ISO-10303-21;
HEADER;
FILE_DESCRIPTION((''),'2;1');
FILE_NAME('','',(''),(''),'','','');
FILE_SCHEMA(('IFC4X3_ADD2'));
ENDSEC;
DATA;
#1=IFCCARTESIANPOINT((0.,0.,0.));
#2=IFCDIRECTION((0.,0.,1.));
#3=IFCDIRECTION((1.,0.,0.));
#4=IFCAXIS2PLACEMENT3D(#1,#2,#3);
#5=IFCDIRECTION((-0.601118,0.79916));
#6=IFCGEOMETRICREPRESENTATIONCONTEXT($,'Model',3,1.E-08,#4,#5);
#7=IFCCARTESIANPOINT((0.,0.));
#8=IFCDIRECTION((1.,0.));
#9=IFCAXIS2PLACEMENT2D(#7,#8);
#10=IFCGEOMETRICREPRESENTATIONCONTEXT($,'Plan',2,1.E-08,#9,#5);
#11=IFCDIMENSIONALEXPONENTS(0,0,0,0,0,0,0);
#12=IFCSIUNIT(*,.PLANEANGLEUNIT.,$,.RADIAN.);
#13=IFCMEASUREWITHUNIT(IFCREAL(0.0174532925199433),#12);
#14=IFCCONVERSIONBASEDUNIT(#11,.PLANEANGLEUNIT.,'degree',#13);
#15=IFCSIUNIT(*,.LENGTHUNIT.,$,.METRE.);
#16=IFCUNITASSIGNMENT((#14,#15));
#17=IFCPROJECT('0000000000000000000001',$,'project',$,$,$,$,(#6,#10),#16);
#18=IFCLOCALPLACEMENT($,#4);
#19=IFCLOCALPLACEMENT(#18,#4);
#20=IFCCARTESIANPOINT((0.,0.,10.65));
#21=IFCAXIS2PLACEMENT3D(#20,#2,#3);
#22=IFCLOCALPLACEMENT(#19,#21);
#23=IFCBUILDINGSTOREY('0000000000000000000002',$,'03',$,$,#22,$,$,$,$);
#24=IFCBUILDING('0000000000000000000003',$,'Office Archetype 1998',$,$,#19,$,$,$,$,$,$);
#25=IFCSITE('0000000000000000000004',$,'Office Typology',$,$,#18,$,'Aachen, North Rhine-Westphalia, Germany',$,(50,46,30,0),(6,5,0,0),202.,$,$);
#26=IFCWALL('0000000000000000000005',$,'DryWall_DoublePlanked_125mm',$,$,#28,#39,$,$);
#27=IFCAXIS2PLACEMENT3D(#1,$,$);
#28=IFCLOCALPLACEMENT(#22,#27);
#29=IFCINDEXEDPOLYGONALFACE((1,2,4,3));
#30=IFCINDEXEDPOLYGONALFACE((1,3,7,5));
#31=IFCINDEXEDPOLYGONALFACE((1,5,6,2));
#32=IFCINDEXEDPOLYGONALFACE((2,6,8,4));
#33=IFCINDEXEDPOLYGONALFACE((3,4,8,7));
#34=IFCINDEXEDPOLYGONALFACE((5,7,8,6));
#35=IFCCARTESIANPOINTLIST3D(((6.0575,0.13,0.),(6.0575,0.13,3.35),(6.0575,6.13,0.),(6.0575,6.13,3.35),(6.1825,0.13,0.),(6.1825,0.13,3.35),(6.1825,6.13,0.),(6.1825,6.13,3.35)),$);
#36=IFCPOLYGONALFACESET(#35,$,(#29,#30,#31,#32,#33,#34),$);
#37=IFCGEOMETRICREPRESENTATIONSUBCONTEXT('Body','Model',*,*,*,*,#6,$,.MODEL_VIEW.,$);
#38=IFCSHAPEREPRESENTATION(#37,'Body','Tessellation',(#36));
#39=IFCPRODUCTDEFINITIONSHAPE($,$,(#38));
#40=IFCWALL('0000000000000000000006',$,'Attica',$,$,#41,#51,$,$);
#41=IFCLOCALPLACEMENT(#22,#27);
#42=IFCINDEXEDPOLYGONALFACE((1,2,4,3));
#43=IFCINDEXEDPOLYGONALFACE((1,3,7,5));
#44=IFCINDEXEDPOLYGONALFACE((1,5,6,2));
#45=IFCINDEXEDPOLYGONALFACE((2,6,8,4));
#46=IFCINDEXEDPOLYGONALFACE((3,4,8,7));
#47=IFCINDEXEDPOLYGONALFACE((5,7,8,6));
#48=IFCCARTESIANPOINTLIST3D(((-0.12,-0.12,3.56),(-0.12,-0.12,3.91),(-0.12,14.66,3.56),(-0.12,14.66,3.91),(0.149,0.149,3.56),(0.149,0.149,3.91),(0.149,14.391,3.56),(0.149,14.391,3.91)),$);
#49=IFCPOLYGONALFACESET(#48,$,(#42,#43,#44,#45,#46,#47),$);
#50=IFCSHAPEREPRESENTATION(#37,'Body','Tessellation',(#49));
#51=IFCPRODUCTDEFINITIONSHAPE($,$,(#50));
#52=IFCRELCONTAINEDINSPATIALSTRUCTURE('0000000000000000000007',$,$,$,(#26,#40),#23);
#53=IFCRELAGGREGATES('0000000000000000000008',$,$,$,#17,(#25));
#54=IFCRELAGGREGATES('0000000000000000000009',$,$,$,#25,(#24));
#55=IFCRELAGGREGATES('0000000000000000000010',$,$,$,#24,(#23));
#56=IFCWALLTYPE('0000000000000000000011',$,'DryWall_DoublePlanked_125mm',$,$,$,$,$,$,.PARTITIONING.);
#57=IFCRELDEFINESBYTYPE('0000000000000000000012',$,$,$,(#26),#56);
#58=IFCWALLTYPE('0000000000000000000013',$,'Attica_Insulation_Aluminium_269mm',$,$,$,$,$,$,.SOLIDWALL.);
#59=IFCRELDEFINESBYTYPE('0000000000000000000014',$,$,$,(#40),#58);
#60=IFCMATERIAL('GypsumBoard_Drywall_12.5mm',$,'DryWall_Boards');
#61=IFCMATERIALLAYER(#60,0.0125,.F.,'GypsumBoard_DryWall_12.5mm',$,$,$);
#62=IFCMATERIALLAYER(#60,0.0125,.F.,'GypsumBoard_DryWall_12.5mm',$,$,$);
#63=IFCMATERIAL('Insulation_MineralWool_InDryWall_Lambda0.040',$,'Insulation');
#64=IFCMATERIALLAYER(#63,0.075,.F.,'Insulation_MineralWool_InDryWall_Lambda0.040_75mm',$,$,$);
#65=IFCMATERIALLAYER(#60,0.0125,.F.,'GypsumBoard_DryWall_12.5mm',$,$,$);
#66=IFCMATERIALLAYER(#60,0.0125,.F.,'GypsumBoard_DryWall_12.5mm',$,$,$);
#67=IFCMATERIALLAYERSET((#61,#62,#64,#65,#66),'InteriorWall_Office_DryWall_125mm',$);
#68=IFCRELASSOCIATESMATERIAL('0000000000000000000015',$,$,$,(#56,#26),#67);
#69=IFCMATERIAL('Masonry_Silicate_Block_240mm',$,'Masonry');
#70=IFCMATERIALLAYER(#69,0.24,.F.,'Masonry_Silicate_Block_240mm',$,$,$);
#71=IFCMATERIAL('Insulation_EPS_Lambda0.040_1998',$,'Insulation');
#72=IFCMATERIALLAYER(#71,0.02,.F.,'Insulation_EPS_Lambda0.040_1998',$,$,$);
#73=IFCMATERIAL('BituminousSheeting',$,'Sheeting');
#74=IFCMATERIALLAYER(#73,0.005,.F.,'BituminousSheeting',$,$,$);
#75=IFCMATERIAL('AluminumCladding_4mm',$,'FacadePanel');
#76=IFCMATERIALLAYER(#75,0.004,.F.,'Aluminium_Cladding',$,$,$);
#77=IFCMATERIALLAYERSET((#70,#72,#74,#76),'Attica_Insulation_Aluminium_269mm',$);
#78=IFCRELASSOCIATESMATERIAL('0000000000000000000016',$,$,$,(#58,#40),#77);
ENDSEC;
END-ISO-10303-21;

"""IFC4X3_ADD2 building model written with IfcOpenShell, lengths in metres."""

from ifc_helpers import new_model, entity, si_unit, converted_unit, direction, frame, origin_with_axes, origin_2d_with_axis, place, context, subcontext, project, spatial, line, indexed_curve, outline, extrude, material, layer, layer_set, layer_usage, type_object, element, save


model = new_model("IFC4X3_ADD2")

# Units and contexts
model_context = context("Model", 3, precision=1e-08, world=origin_with_axes(), true_north=direction((-0.601118, 0.79916)))
plan_context = context("Plan", 2, precision=1e-08, world=origin_2d_with_axis(), true_north=direction((-0.601118, 0.79916)))
body_context = subcontext(model_context, "Body", "Model", "MODEL_VIEW")
ifc_project = project(units=[converted_unit("PLANEANGLEUNIT", "degree", entity("IfcReal", 0.0174532925199433), si_unit("PLANEANGLEUNIT", "RADIAN"), dimensions=[0, 0, 0, 0, 0, 0, 0]), si_unit("LENGTHUNIT", "METRE")], contexts=[model_context, plan_context])

# Site, building, storey
site_placement = place(None, origin_with_axes())
site = spatial("IfcSite", under=ifc_project, at=site_placement, Name="Office Typology", LongName="Aachen, North Rhine-Westphalia, Germany", RefLatitude=(50, 46, 30, 0), RefLongitude=(6, 5, 0, 0), RefElevation=202.0)
building_placement = place(site_placement, origin_with_axes())
building = spatial("IfcBuilding", under=site, at=building_placement, Name="Office Archetype 1998")
storey_placement = place(building_placement, frame((0.0, 0.0, 10.65), z_axis=(0.0, 0.0, 1.0), x_axis=(1.0, 0.0, 0.0)))
storey = spatial("IfcBuildingStorey", under=building, at=storey_placement, Name="03")

# Shared definitions
ifc_material_1 = material(Name="Masonry_Silicate_Block_240mm", Category="Masonry")

# Wall
ifc_material_2 = material(Name="GypsumBoard_Drywall_12.5mm", Category="DryWall_Boards")
ifc_layer_1 = layer(ifc_material_2, 0.0125, ventilated=False, Name="GypsumBoard_DryWall_12.5mm")
ifc_layer_2 = layer(ifc_material_2, 0.0125, ventilated=False, Name="GypsumBoard_DryWall_12.5mm")
ifc_material_3 = material(Name="Insulation_MineralWool_InDryWall_Lambda0.040", Category="Insulation")
ifc_layer_3 = layer(ifc_material_3, 0.075, ventilated=False, Name="Insulation_MineralWool_InDryWall_Lambda0.040_75mm")
ifc_layer_4 = layer(ifc_material_2, 0.0125, ventilated=False, Name="GypsumBoard_DryWall_12.5mm")
ifc_layer_5 = layer(ifc_material_2, 0.0125, ventilated=False, Name="GypsumBoard_DryWall_12.5mm")
ifc_layer_set_1 = layer_set([ifc_layer_1, ifc_layer_2, ifc_layer_3, ifc_layer_4, ifc_layer_5], Name="InteriorWall_Office_DryWall_125mm")
ifc_layer_usage_1 = layer_usage(ifc_layer_set_1, "AXIS2", "POSITIVE", 0.0)
wall_type_1 = type_object("IfcWallType", Name="DryWall_DoublePlanked_125mm", PredefinedType="PARTITIONING", material=ifc_layer_set_1)
wall_1_placement = place(storey_placement, frame((6.0575, 6.13, 0.0), z_axis=(0.0, 0.0, 1.0), x_axis=(0.0, -1.0, 0.0)))
element("IfcWall", 1, at=wall_1_placement, inside=storey, type_object=wall_type_1, material=ifc_layer_usage_1, Name="DryWall_DoublePlanked_125mm", context=body_context, shape_type="SweptSolid", body=[
    extrude(outline(indexed_curve([(0.0, 0.0), (0.0, 0.125), (6.0, 0.125), (6.0, 0.0)], segments=[line(1, 2, 3, 4, 1)])), origin_with_axes(), (0.0, 0.0, 1.0), 3.35),
])

# Wall
ifc_layer_6 = layer(ifc_material_1, 0.24, ventilated=False, Name="Masonry_Silicate_Block_240mm")
ifc_material_4 = material(Name="Insulation_EPS_Lambda0.040_1998", Category="Insulation")
ifc_layer_7 = layer(ifc_material_4, 0.02, ventilated=False, Name="Insulation_EPS_Lambda0.040_1998")
ifc_material_5 = material(Name="BituminousSheeting", Category="Sheeting")
ifc_layer_8 = layer(ifc_material_5, 0.005, ventilated=False, Name="BituminousSheeting")
ifc_material_6 = material(Name="AluminumCladding_4mm", Category="FacadePanel")
ifc_layer_9 = layer(ifc_material_6, 0.004, ventilated=False, Name="Aluminium_Cladding")
ifc_layer_set_2 = layer_set([ifc_layer_6, ifc_layer_7, ifc_layer_8, ifc_layer_9], Name="Attica_Insulation_Aluminium_269mm")
ifc_layer_usage_2 = layer_usage(ifc_layer_set_2, "AXIS2", "POSITIVE", 0.0)
wall_type_2 = type_object("IfcWallType", Name="Attica_Insulation_Aluminium_269mm", PredefinedType="SOLIDWALL", material=ifc_layer_set_2)
wall_2_placement = place(storey_placement, frame((-0.12, 14.66, 3.56), z_axis=(0.0, 0.0, 1.0), x_axis=(0.0, -1.0, 0.0)))
element("IfcWall", 2, at=wall_2_placement, inside=storey, type_object=wall_type_2, material=ifc_layer_usage_2, Name="Attica", context=body_context, shape_type="SweptSolid", body=[
    extrude(outline(indexed_curve([(0.0, 0.0), (0.269, 0.269), (14.511, 0.269), (14.78, 0.0)], segments=[line(1, 2, 3, 4, 1)])), origin_with_axes(), (0.0, 0.0, 1.0), 0.35),
])

save(model, "model.ifc")
